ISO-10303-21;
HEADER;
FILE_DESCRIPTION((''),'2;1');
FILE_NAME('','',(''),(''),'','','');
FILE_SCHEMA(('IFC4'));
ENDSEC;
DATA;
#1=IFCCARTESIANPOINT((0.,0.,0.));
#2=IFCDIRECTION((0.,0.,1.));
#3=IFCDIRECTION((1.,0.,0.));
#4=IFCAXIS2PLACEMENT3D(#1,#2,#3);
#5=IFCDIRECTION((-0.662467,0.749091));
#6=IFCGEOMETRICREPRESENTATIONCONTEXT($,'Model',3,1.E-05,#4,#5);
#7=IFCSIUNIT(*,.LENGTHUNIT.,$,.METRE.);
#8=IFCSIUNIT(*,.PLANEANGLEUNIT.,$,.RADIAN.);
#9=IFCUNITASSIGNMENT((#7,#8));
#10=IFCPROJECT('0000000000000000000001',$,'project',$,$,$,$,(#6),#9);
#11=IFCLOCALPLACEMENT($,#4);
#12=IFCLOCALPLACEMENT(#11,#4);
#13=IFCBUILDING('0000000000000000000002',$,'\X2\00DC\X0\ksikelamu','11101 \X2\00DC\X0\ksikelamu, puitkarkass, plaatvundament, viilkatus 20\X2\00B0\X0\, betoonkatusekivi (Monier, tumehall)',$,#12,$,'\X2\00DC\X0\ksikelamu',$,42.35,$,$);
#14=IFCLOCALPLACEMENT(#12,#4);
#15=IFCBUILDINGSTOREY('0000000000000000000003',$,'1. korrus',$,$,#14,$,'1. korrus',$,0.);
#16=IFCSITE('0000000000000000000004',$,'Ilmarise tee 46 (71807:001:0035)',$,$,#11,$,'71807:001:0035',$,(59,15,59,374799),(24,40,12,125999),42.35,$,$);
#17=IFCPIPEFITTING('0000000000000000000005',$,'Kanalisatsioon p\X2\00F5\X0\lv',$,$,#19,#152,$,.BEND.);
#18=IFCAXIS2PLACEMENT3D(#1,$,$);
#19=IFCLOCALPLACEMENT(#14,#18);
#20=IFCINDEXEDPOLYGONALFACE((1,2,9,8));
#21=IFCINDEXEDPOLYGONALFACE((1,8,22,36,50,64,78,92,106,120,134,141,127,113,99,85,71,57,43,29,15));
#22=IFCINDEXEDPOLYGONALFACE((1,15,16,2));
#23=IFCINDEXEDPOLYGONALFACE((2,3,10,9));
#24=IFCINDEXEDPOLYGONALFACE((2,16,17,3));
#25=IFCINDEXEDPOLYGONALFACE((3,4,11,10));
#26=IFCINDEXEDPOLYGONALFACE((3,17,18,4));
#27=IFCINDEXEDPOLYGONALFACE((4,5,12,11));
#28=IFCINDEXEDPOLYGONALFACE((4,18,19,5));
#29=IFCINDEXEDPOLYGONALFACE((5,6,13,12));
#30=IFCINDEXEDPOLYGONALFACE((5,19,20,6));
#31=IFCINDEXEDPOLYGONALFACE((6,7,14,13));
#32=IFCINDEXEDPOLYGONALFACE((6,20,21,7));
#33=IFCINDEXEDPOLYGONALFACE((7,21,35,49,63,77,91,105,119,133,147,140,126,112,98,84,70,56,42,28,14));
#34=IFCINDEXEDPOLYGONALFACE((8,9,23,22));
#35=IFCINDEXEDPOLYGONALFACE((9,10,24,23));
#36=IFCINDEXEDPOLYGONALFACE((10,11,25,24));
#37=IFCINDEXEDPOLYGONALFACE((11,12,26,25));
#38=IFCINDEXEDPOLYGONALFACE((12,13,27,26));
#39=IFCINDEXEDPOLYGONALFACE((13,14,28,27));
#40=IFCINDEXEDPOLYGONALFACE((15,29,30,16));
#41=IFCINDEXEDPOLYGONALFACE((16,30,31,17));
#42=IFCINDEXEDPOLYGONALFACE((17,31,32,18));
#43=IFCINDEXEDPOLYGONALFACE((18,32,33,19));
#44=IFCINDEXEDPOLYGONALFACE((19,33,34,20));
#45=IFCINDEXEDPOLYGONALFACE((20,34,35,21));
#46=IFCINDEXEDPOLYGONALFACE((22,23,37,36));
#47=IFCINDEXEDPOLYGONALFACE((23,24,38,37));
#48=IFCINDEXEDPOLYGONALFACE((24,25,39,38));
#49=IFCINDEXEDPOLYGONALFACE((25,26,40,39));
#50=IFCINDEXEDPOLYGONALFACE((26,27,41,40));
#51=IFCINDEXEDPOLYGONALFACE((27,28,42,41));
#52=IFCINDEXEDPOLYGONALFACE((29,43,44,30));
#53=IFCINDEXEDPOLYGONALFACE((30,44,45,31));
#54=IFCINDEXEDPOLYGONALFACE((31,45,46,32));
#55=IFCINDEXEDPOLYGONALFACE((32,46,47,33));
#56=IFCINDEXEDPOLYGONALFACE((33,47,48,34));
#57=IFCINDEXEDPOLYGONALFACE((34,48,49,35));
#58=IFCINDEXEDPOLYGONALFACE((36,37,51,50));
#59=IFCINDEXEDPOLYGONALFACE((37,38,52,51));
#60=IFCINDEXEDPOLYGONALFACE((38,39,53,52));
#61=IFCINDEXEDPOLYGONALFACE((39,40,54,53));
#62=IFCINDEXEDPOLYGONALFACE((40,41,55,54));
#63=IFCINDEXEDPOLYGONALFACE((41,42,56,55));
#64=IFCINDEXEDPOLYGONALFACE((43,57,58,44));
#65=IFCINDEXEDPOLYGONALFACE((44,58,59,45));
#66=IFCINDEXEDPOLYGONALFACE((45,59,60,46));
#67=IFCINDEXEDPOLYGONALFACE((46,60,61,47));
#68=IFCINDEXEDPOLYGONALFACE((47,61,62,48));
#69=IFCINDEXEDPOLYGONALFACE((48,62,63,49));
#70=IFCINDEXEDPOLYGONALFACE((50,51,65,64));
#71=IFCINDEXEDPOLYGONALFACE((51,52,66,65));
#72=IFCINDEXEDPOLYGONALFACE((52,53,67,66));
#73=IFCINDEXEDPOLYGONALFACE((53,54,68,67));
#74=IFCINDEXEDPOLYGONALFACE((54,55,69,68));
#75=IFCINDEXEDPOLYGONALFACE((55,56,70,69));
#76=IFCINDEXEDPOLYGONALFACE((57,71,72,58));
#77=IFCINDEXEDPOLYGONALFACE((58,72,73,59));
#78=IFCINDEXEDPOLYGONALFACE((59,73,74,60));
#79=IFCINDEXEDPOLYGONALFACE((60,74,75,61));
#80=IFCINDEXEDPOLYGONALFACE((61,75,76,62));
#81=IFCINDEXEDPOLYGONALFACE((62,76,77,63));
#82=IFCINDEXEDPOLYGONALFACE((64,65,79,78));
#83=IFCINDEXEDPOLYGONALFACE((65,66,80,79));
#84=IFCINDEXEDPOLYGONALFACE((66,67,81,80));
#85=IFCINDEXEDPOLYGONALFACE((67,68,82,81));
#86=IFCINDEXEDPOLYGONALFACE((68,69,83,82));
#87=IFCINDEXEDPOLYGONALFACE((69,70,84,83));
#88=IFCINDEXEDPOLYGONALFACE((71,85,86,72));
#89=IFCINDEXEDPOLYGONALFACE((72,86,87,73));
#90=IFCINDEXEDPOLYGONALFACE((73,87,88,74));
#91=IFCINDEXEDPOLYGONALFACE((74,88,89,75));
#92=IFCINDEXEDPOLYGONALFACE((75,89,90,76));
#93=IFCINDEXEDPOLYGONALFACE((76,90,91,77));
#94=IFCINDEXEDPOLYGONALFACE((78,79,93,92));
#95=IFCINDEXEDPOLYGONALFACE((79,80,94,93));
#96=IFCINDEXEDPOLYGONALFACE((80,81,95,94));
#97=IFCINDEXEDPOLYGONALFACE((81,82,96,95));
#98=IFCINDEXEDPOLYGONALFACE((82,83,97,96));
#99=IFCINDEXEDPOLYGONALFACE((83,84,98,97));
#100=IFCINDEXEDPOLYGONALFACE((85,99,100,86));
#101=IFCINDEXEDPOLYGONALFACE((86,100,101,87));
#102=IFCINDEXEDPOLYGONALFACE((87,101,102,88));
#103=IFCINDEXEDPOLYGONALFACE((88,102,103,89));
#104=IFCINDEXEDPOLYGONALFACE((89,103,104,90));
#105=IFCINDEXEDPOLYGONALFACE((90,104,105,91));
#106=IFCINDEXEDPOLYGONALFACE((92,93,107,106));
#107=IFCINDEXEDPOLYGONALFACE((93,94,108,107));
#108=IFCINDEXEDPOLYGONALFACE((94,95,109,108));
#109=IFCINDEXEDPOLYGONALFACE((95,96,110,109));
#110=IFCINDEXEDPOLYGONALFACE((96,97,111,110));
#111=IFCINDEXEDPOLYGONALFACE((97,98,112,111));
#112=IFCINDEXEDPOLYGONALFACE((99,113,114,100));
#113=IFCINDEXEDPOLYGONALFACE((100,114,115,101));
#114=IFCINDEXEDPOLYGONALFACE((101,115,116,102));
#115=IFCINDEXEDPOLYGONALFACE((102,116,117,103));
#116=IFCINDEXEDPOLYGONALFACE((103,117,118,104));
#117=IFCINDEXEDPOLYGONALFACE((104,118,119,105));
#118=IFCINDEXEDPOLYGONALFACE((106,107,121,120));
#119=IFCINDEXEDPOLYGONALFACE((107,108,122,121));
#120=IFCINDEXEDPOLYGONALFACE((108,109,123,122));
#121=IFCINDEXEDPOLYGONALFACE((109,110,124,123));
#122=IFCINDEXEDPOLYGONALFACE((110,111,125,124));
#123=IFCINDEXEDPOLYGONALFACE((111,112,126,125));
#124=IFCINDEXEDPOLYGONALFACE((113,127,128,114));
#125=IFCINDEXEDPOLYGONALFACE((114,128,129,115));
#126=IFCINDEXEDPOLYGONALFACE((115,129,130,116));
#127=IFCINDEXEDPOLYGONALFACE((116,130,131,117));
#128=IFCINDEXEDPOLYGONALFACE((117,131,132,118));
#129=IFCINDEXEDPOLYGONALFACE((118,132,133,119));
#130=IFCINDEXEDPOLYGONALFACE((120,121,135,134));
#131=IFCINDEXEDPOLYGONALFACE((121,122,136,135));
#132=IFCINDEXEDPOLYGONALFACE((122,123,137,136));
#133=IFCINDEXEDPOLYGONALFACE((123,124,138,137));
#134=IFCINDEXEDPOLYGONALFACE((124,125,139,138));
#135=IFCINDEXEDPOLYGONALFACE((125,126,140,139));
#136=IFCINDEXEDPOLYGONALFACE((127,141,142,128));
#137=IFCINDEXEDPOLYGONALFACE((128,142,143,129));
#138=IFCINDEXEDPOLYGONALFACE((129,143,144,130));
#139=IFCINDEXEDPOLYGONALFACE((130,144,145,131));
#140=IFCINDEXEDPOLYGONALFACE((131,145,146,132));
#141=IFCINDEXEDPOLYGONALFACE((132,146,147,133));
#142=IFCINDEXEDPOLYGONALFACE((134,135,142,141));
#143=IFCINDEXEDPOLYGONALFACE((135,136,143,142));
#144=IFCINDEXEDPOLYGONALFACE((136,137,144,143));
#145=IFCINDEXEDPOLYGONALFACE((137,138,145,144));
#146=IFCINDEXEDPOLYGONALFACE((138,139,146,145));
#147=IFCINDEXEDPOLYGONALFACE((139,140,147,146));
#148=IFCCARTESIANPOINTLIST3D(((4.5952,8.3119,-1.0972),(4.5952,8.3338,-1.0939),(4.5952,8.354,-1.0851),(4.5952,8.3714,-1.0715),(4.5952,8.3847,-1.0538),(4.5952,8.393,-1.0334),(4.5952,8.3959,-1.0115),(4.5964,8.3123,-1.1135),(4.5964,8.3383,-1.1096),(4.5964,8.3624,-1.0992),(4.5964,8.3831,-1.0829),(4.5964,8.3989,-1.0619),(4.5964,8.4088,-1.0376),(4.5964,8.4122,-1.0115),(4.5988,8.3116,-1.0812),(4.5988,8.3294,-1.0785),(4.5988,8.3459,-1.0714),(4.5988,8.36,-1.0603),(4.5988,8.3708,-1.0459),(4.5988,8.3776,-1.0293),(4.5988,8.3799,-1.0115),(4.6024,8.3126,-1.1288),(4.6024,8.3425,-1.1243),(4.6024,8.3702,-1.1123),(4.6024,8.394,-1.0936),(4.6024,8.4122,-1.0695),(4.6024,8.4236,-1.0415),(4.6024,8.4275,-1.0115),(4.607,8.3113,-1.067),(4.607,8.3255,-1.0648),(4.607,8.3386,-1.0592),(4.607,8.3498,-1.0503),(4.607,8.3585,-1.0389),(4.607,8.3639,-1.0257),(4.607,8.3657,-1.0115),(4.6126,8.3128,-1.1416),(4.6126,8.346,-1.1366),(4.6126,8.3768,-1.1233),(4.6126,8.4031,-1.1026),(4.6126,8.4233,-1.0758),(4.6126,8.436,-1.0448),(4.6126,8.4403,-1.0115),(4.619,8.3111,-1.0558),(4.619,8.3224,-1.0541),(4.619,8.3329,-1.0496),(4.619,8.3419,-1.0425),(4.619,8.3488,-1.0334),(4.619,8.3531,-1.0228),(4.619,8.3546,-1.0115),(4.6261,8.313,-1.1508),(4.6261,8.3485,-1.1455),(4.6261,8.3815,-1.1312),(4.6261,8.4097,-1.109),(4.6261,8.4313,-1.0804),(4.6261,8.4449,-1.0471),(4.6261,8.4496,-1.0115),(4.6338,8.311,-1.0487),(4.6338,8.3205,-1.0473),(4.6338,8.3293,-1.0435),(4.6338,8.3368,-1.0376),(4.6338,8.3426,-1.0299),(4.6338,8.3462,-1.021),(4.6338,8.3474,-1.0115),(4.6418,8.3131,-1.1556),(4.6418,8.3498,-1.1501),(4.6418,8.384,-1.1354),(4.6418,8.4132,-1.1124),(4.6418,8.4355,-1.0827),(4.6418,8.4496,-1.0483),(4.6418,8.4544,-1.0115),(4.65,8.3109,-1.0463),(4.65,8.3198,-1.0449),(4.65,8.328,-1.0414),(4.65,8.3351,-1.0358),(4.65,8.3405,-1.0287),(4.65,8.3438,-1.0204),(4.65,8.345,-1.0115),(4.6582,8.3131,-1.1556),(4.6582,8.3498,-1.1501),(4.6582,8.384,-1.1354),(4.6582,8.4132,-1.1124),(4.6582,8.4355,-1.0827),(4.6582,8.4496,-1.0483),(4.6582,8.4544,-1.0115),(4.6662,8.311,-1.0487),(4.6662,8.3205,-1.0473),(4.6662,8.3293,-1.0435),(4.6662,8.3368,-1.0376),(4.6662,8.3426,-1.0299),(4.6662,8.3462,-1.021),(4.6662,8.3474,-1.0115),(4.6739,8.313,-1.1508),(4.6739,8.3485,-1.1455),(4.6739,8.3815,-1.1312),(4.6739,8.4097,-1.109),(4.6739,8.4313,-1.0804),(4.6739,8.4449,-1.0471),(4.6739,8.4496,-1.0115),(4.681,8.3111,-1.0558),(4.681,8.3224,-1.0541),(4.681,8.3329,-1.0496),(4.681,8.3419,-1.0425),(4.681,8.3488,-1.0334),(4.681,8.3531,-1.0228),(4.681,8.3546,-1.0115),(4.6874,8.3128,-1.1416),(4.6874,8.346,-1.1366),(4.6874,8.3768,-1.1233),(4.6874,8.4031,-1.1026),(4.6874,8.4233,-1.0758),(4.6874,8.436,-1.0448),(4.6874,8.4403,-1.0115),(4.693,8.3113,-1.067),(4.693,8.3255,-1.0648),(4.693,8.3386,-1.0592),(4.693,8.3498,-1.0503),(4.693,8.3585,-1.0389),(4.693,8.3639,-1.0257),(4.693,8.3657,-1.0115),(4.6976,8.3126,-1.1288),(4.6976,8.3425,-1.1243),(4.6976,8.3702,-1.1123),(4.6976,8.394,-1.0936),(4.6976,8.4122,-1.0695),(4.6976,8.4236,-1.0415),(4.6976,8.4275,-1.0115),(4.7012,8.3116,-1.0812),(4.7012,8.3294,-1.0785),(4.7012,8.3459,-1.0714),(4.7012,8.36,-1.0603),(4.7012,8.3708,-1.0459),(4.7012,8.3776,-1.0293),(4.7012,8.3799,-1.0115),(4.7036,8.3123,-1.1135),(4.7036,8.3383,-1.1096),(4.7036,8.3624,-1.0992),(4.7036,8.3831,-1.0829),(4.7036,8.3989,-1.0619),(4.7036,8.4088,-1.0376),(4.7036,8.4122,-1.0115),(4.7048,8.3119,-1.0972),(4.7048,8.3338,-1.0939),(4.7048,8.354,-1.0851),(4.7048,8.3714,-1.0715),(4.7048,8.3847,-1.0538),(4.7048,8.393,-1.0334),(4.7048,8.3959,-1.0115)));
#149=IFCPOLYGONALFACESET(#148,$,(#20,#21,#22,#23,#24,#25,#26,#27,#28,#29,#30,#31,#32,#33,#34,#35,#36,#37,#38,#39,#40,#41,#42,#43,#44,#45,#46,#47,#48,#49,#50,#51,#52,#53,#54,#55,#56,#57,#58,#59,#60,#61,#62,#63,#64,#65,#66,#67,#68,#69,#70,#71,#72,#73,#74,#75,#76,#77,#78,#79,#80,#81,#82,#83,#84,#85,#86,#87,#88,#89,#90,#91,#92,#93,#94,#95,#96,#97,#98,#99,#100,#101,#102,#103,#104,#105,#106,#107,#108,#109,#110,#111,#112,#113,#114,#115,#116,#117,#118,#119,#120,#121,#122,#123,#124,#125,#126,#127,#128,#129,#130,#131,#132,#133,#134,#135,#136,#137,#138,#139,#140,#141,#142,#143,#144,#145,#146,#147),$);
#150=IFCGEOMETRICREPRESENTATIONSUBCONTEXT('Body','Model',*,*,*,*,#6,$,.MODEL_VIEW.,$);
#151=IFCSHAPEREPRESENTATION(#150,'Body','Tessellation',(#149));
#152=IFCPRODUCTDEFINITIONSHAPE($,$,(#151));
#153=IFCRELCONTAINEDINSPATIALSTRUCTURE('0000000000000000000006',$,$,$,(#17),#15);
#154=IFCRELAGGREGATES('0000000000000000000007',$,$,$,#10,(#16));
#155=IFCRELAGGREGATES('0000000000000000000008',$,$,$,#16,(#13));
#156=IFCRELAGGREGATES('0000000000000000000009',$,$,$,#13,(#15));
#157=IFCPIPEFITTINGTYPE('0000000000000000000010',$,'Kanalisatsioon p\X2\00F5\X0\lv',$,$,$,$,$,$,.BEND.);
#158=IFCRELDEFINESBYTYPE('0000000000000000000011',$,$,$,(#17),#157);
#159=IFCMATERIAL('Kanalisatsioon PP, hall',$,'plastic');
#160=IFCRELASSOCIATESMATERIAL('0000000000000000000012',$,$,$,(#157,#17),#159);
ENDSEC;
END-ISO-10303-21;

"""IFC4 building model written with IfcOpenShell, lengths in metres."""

from ifc_helpers import new_model, entity, si_unit, direction, frame, origin_with_axes, place, context, subcontext, project, spatial, material, type_object, element, save


model = new_model("IFC4")

# Units and contexts
model_context = context("Model", 3, precision=1e-05, world=origin_with_axes(), true_north=direction((-0.662467, 0.749091)))
body_context = subcontext(model_context, "Body", "Model", "MODEL_VIEW")
ifc_project = project(units=[si_unit("LENGTHUNIT", "METRE"), si_unit("PLANEANGLEUNIT", "RADIAN")], contexts=[model_context])

# Site, building, storey
site_placement = place(None, origin_with_axes())
site = spatial("IfcSite", under=ifc_project, at=site_placement, Name="Ilmarise tee 46 (71807:001:0035)", LongName="71807:001:0035", RefLatitude=(59, 15, 59, 374799), RefLongitude=(24, 40, 12, 125999), RefElevation=42.35)
building_placement = place(site_placement, origin_with_axes())
building = spatial("IfcBuilding", under=site, at=building_placement, Name="Üksikelamu", Description="11101 Üksikelamu, puitkarkass, plaatvundament, viilkatus 20°, betoonkatusekivi (Monier, tumehall)", LongName="Üksikelamu", ElevationOfRefHeight=42.35)
storey_placement = place(building_placement, origin_with_axes())
storey = spatial("IfcBuildingStorey", under=building, at=storey_placement, Name="1. korrus", LongName="1. korrus", Elevation=0.0)

# Pipe fitting
ifc_material_1 = material(Name="Kanalisatsioon PP, hall", Category="plastic")
pipe_fitting_type_1 = type_object("IfcPipeFittingType", Name="Kanalisatsioon põlv", PredefinedType="BEND", material=ifc_material_1)
pipe_fitting_1_placement = place(storey_placement, frame((4.65, 8.4, -1.0995), z_axis=(0.0, 0.0, 1.0), x_axis=(1.0, 0.0, 0.0)))
element("IfcPipeFitting", 1, at=pipe_fitting_1_placement, inside=storey, type_object=pipe_fitting_type_1, material=ifc_material_1, Name="Kanalisatsioon põlv", PredefinedType="BEND", context=body_context, shape_type="SweptSolid", body=[
    entity("IfcRevolvedAreaSolid", entity("IfcCircleProfileDef", "AREA", None, None, 0.055), entity("IfcAxis2Placement3D", entity("IfcCartesianPoint", [0.0, -0.088, -0.0018]), entity("IfcDirection", [0.0, 0.9998, 0.019996]), entity("IfcDirection", [0.0, -0.019996, 0.9998])), entity("IfcAxis1Placement", entity("IfcCartesianPoint", [0.0898, 0.0, 0.0]), entity("IfcDirection", [0.0, 1.0, 0.0])), 1.550799),
])

save(model, "model.ifc")
